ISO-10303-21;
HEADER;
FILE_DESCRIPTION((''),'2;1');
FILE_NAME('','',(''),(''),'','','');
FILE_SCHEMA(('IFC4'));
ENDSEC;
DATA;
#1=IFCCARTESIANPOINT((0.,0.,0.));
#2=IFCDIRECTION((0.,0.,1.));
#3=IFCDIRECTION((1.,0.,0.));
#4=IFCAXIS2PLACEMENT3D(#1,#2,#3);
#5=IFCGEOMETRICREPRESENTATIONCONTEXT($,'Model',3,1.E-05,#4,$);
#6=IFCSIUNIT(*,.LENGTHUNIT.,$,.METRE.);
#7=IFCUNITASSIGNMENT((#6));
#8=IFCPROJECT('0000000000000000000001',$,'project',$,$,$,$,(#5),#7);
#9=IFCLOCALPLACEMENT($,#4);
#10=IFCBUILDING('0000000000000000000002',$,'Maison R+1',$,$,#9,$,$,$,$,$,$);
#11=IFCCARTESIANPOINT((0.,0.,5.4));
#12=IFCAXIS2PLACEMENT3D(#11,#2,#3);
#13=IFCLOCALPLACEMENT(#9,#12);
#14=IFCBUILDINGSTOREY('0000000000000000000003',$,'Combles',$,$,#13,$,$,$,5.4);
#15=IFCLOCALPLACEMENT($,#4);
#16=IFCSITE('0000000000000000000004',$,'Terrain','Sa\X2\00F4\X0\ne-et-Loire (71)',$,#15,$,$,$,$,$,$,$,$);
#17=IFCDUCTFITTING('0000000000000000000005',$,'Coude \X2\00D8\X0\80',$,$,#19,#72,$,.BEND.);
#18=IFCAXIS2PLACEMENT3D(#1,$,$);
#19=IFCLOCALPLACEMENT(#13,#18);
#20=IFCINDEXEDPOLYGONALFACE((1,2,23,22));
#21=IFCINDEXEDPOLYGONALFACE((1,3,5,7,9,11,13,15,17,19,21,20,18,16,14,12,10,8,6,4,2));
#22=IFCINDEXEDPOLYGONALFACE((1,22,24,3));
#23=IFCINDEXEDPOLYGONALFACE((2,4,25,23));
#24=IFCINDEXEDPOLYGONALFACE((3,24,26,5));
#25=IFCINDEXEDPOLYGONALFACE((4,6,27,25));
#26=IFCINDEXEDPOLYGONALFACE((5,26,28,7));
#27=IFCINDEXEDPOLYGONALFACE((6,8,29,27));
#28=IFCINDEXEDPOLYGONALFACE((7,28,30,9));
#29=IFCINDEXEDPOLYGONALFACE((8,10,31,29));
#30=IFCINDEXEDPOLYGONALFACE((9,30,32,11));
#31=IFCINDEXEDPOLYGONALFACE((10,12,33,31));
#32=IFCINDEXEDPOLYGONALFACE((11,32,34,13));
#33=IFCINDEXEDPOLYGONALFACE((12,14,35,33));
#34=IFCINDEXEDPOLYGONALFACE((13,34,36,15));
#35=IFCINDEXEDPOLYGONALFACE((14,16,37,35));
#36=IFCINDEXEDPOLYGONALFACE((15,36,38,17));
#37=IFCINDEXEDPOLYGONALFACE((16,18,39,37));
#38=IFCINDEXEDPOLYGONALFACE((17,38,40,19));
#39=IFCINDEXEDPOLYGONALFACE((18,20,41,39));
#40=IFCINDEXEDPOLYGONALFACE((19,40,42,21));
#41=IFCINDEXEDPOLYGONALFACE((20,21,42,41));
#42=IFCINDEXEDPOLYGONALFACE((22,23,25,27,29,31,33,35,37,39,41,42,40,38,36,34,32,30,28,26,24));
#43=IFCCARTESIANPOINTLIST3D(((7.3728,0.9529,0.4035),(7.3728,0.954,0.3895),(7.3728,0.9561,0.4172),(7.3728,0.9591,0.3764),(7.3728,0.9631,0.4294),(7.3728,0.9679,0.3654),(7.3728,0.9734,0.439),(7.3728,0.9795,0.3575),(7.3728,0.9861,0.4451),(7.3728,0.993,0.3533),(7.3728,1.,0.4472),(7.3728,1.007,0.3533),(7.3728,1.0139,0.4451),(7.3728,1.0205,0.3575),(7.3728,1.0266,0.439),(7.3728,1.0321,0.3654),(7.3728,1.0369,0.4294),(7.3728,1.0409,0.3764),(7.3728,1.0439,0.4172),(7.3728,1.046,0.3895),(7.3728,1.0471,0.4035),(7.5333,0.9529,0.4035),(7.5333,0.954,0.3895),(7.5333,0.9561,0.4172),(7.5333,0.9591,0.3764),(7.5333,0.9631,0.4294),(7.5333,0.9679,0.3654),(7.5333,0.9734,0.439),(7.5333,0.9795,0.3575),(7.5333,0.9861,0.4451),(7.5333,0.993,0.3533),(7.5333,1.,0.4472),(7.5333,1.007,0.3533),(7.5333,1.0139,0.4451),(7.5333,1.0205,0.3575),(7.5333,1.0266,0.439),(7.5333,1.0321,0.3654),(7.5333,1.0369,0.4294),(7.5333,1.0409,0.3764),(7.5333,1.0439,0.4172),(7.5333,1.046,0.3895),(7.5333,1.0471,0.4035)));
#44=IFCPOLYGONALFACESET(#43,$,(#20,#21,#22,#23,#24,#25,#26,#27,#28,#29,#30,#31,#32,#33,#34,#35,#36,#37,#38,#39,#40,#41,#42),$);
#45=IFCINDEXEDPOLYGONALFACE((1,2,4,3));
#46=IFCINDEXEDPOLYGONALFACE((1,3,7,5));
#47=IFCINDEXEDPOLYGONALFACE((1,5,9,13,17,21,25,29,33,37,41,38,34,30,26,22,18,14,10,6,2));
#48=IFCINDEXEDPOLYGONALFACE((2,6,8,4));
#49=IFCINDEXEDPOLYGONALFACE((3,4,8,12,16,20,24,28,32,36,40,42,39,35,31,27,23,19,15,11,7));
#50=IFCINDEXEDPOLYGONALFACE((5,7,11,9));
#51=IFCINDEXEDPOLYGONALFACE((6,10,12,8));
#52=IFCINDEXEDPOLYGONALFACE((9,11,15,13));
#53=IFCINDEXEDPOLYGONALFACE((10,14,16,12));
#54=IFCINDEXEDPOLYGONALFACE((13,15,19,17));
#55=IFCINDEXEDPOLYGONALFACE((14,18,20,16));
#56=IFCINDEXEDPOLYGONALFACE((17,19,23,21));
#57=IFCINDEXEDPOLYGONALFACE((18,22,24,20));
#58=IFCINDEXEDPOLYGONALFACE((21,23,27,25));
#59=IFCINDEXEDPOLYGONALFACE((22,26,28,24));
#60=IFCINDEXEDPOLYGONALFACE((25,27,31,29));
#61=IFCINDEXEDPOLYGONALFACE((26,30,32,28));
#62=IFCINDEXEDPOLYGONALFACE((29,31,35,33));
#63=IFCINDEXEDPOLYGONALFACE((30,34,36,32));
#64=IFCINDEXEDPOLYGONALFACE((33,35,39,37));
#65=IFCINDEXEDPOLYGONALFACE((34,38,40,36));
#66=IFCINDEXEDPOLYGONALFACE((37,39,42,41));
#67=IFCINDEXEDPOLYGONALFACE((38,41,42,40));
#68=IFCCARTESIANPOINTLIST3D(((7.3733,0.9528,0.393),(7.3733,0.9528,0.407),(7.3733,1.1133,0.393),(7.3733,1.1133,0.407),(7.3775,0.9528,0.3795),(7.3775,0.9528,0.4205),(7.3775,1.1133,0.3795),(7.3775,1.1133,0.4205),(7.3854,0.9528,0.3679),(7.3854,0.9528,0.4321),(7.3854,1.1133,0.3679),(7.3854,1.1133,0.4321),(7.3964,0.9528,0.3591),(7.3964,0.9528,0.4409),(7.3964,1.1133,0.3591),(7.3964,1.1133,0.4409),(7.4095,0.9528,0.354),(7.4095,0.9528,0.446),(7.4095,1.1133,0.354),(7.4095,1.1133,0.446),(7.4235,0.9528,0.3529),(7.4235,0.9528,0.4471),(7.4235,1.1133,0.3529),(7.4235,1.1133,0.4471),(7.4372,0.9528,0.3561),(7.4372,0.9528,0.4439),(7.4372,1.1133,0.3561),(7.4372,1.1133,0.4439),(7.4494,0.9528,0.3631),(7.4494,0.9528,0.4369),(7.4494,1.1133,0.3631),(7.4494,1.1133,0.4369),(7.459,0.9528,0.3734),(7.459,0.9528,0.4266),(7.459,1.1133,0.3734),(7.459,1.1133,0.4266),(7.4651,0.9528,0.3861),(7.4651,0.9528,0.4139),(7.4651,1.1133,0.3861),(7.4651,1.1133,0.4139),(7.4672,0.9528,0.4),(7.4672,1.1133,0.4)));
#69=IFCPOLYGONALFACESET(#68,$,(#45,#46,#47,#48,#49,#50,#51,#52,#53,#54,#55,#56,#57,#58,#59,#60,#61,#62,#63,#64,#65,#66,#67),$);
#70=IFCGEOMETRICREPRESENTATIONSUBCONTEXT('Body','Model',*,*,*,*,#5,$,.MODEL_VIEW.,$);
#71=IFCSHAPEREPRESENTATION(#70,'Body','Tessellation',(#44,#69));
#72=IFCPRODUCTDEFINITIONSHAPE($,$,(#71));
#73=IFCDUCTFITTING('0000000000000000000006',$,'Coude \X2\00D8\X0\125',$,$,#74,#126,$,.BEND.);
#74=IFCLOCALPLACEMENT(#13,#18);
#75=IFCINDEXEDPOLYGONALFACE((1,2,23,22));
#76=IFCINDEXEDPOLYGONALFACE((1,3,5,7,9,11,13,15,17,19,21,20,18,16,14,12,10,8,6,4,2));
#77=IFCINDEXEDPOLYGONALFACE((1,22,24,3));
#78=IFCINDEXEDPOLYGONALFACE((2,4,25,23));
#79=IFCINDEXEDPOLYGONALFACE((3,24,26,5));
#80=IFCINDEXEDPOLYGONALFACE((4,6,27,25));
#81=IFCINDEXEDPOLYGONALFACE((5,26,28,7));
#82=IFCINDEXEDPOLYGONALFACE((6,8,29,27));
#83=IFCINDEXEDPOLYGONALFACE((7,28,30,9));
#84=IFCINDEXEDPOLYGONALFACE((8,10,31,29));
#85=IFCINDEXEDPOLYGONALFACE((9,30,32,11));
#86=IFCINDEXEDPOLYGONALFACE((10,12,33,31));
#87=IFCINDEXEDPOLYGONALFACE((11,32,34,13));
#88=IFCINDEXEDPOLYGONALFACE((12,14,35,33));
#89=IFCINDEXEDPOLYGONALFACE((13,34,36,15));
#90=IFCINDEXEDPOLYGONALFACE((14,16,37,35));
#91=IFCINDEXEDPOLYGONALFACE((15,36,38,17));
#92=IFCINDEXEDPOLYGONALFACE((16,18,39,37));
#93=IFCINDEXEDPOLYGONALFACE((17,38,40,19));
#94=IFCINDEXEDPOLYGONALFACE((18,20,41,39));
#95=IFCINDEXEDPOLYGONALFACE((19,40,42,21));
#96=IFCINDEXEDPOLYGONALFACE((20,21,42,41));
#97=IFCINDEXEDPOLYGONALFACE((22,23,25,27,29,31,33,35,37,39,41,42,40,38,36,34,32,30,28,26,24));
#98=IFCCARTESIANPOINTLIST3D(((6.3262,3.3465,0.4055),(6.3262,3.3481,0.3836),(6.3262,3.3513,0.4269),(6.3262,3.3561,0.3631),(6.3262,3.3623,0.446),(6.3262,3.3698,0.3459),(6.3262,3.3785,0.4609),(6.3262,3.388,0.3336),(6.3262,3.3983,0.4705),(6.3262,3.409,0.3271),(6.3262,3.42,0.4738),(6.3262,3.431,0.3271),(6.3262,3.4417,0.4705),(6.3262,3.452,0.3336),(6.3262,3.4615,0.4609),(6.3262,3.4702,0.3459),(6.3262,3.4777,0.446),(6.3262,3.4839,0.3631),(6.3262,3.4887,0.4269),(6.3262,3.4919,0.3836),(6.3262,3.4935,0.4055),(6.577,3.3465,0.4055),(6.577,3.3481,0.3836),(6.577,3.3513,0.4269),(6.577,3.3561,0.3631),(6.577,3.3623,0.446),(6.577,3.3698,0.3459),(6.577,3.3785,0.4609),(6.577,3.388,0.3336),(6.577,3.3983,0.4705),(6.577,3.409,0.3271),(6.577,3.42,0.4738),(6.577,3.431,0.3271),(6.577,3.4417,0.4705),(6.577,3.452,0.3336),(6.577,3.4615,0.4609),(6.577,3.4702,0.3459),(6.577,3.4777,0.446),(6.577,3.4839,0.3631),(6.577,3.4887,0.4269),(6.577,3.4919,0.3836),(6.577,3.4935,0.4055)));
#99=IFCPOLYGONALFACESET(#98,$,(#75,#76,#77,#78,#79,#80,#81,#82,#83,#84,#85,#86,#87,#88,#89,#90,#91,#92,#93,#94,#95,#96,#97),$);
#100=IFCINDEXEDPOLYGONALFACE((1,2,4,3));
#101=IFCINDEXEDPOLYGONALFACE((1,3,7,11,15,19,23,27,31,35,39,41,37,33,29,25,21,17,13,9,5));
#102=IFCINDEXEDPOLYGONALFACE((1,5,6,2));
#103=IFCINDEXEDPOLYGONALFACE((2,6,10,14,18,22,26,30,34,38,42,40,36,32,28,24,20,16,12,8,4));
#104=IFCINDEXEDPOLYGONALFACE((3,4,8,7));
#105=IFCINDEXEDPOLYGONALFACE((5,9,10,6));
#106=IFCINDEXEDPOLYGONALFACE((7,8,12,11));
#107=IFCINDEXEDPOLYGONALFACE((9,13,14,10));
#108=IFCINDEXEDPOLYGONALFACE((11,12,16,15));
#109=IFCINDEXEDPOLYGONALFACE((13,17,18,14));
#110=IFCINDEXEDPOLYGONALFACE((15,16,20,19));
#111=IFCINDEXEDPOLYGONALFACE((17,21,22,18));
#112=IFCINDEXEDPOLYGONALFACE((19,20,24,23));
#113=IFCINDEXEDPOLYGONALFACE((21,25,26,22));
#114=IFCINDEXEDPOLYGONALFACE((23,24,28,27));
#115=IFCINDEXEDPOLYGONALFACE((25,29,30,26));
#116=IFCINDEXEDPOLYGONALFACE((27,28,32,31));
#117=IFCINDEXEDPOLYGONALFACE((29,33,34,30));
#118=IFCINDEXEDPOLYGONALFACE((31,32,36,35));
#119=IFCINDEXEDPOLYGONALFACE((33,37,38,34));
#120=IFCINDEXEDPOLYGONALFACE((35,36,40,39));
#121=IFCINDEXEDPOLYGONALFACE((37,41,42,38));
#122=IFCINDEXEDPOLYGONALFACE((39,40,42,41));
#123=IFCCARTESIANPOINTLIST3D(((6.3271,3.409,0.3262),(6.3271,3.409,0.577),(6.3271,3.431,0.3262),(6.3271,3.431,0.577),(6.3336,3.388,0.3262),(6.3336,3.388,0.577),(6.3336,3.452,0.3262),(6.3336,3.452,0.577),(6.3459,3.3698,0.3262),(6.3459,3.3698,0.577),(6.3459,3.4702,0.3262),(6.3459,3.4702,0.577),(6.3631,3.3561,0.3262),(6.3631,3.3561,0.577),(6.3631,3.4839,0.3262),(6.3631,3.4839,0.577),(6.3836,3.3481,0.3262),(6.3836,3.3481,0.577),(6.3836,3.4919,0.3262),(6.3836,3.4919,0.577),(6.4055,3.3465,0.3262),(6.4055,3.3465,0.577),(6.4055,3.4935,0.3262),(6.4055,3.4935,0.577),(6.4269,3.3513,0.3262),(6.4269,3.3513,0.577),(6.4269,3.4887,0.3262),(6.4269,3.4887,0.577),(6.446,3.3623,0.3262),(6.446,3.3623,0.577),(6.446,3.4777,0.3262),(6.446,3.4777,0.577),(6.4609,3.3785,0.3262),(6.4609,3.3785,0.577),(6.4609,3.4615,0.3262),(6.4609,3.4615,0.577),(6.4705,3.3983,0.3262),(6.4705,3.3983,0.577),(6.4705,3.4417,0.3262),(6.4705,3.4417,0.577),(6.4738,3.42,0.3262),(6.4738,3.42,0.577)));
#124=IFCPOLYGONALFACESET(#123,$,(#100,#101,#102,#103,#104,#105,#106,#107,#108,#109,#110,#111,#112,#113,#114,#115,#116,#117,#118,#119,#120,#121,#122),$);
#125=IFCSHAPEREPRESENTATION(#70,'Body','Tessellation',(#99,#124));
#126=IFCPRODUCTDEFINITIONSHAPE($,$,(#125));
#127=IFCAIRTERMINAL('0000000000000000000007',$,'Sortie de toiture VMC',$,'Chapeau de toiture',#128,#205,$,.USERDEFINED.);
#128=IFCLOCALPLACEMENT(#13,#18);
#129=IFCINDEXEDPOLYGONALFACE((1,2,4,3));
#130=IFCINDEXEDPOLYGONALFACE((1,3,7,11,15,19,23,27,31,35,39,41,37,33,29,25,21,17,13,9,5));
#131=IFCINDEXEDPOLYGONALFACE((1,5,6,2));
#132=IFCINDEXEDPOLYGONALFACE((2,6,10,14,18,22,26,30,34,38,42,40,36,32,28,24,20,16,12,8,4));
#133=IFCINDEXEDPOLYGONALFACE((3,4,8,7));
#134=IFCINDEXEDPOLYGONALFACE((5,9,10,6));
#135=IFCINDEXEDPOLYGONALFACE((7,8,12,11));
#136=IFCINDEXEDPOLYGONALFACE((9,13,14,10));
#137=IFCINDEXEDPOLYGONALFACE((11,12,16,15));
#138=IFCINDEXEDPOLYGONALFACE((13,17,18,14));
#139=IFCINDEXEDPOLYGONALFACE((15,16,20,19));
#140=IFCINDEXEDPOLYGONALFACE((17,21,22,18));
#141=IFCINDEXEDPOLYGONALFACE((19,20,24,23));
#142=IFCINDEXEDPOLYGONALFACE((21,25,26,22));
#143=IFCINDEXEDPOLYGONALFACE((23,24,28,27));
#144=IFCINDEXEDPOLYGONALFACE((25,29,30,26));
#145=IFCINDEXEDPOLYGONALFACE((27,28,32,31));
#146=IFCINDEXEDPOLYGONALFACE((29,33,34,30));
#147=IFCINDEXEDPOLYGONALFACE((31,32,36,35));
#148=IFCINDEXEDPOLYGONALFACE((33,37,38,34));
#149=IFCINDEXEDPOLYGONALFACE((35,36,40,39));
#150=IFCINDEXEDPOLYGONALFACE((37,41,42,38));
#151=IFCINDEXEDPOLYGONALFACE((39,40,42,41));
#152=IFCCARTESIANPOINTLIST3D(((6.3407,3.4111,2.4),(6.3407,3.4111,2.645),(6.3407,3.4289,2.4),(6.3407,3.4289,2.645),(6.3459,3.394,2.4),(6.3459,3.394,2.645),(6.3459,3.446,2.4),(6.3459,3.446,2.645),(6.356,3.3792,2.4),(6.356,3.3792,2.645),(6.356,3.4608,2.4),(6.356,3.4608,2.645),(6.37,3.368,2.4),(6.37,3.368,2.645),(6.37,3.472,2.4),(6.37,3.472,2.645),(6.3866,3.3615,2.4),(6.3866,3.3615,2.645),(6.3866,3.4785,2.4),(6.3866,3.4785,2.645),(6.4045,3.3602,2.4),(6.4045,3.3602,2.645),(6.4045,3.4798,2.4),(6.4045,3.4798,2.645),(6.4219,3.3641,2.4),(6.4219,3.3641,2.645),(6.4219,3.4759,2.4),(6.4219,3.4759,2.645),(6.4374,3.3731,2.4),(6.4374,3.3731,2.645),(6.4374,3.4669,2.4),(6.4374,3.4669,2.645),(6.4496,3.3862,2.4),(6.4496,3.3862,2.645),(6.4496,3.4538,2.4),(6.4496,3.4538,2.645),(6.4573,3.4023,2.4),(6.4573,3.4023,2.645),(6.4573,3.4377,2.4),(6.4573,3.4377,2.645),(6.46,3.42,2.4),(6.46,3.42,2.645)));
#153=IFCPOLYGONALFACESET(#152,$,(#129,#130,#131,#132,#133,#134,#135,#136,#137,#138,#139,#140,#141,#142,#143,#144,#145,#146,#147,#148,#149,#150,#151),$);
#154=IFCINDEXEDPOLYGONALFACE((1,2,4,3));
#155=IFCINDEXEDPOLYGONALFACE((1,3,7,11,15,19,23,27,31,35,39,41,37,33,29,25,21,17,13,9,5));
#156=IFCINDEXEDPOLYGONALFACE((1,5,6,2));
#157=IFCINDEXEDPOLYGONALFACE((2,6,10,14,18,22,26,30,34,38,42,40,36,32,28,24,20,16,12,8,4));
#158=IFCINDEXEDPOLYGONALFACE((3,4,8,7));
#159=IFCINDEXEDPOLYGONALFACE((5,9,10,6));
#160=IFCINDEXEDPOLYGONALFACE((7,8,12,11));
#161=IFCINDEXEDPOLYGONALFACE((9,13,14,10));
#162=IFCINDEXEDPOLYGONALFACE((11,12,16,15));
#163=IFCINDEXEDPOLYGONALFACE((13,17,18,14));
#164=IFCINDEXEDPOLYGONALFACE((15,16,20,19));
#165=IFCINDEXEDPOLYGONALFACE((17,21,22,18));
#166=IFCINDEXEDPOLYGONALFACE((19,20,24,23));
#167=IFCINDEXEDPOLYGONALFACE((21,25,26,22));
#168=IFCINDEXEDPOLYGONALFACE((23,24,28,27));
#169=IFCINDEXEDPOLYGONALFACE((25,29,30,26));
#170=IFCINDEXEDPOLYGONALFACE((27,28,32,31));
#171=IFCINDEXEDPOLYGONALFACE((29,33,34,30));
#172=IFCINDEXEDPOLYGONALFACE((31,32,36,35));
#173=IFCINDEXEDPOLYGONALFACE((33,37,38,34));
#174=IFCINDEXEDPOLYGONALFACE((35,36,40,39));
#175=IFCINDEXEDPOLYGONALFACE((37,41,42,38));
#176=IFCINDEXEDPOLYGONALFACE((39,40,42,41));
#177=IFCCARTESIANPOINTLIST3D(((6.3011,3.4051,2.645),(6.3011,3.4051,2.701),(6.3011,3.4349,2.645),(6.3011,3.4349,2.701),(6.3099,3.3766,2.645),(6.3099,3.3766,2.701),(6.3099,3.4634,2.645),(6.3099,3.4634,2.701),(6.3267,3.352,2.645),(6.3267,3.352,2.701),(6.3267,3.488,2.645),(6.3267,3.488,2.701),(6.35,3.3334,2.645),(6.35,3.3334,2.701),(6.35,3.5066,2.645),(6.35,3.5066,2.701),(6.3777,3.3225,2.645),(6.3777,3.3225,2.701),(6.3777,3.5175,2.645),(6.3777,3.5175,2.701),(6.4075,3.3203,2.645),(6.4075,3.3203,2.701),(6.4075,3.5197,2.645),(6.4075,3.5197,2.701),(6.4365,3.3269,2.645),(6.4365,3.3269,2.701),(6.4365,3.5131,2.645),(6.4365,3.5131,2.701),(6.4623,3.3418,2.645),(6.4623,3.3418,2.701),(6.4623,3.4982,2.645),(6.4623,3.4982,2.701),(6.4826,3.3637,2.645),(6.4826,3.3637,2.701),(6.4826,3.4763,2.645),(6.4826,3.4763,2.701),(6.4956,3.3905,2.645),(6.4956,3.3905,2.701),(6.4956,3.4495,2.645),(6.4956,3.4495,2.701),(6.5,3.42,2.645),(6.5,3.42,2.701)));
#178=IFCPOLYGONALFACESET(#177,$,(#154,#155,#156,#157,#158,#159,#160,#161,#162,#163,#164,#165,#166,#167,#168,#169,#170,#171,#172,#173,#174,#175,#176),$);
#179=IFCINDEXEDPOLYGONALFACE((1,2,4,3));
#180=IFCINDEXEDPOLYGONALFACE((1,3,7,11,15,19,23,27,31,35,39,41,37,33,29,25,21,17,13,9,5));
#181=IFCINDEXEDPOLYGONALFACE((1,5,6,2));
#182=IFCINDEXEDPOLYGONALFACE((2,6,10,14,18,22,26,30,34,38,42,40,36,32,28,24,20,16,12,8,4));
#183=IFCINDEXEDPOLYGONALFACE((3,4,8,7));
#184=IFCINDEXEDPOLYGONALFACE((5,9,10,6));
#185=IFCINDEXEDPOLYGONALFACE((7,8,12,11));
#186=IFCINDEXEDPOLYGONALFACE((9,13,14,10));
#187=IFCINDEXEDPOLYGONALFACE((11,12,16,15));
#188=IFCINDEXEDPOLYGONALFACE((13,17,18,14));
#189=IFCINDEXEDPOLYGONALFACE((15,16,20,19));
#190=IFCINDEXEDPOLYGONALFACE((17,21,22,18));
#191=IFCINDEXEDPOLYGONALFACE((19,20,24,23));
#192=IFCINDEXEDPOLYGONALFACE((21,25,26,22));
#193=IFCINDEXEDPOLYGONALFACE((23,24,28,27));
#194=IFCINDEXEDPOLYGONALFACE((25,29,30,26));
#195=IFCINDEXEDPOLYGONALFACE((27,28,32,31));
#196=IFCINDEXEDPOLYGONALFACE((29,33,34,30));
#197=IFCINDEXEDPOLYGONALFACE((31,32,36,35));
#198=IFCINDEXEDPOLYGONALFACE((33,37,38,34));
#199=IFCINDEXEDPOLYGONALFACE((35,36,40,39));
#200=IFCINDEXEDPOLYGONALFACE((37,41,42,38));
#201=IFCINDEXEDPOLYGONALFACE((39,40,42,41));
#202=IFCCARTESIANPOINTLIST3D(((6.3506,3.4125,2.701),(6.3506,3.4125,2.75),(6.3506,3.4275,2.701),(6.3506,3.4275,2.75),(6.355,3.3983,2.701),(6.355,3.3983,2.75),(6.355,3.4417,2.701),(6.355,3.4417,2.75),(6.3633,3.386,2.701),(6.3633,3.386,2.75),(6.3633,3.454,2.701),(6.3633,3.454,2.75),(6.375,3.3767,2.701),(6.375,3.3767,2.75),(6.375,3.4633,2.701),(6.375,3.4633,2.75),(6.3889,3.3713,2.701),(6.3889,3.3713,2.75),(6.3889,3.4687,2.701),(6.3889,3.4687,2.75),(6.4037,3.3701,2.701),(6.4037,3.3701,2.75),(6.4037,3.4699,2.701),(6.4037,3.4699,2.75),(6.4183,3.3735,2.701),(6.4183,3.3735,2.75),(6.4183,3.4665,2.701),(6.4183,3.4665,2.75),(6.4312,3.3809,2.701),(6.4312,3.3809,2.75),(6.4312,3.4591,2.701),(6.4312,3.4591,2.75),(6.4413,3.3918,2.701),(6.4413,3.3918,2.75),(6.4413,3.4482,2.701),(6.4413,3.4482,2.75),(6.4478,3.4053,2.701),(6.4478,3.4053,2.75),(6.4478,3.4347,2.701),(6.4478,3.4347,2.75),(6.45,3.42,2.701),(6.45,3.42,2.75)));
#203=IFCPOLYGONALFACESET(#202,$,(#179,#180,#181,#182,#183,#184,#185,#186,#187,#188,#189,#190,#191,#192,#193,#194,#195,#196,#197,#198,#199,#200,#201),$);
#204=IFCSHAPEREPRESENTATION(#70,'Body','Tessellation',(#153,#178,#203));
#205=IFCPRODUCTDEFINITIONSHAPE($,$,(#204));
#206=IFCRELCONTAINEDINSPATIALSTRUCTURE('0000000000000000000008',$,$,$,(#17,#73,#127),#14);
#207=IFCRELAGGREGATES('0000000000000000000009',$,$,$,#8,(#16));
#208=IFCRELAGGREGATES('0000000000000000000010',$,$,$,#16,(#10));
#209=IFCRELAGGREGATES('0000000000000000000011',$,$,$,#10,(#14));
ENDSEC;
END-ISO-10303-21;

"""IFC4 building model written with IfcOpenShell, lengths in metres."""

from ifc_helpers import new_model, si_unit, frame, origin_with_axes, place, context, subcontext, project, spatial, circle, extrude, element, save


model = new_model("IFC4")

# Units and contexts
model_context = context("Model", 3, precision=1e-05, world=origin_with_axes())
body_context = subcontext(model_context, "Body", "Model", "MODEL_VIEW")
ifc_project = project(units=[si_unit("LENGTHUNIT", "METRE")], contexts=[model_context])

# Site, building, storey
site_placement = place(None, origin_with_axes())
site = spatial("IfcSite", under=ifc_project, at=site_placement, Name="Terrain", Description="Saône-et-Loire (71)")
building_placement = place(None, origin_with_axes())
building = spatial("IfcBuilding", under=site, at=building_placement, Name="Maison R+1")
storey_placement = place(building_placement, frame((0.0, 0.0, 5.4), z_axis=(0.0, 0.0, 1.0), x_axis=(1.0, 0.0, 0.0)))
storey = spatial("IfcBuildingStorey", under=building, at=storey_placement, Name="Combles", Elevation=5.4)

# Duct fittings
duct_fitting_1_placement = place(storey_placement, frame((7.42, 1.0, 0.4), z_axis=(0.0, 0.0, 1.0), x_axis=(1.0, 0.0, 0.0)))
element("IfcDuctFitting", 1, at=duct_fitting_1_placement, inside=storey, Name="Coude Ø80", PredefinedType="BEND", context=body_context, shape_type="SweptSolid", body=[
    extrude(circle(Radius=0.0472), frame((-0.0472, 0.0, 0.0), z_axis=(1.0, 0.0, 0.0), x_axis=(0.0, 0.0, 1.0)), (0.0, 0.0, 1.0), 0.1605),
    extrude(circle(Radius=0.0472), frame((0.0, -0.0472, 0.0), z_axis=(0.0, 1.0, 0.0), x_axis=(1.0, 0.0, 0.0)), (0.0, 0.0, 1.0), 0.1605),
])
duct_fitting_2_placement = place(storey_placement, frame((6.4, 3.42, 0.4), z_axis=(0.0, 0.0, 1.0), x_axis=(1.0, 0.0, 0.0)))
element("IfcDuctFitting", 2, at=duct_fitting_2_placement, inside=storey, Name="Coude Ø125", PredefinedType="BEND", context=body_context, shape_type="SweptSolid", body=[
    extrude(circle(Radius=0.0737), frame((-0.0737, 0.0, 0.0), z_axis=(1.0, 0.0, 0.0), x_axis=(0.0, 0.0, 1.0)), (0.0, 0.0, 1.0), 0.2507),
    extrude(circle(Radius=0.0737), frame((0.0, 0.0, -0.0737), z_axis=(0.0, 0.0, 1.0), x_axis=(1.0, 0.0, 0.0)), (0.0, 0.0, 1.0), 0.2507),
])

# Air terminal
air_terminal_placement = place(storey_placement, frame((6.4, 3.42, 2.4), z_axis=(0.0, 0.0, 1.0), x_axis=(1.0, 0.0, 0.0)))
element("IfcAirTerminal", 3, at=air_terminal_placement, inside=storey, Name="Sortie de toiture VMC", ObjectType="Chapeau de toiture", PredefinedType="USERDEFINED", context=body_context, shape_type="SweptSolid", body=[
    extrude(circle(Radius=0.06), origin_with_axes(), (0.0, 0.0, 1.0), 0.245),
    extrude(circle(Radius=0.1), frame((0.0, 0.0, 0.245), z_axis=(0.0, 0.0, 1.0), x_axis=(1.0, 0.0, 0.0)), (0.0, 0.0, 1.0), 0.056),
    extrude(circle(Radius=0.05), frame((0.0, 0.0, 0.301), z_axis=(0.0, 0.0, 1.0), x_axis=(1.0, 0.0, 0.0)), (0.0, 0.0, 1.0), 0.049),
])

save(model, "model.ifc")
